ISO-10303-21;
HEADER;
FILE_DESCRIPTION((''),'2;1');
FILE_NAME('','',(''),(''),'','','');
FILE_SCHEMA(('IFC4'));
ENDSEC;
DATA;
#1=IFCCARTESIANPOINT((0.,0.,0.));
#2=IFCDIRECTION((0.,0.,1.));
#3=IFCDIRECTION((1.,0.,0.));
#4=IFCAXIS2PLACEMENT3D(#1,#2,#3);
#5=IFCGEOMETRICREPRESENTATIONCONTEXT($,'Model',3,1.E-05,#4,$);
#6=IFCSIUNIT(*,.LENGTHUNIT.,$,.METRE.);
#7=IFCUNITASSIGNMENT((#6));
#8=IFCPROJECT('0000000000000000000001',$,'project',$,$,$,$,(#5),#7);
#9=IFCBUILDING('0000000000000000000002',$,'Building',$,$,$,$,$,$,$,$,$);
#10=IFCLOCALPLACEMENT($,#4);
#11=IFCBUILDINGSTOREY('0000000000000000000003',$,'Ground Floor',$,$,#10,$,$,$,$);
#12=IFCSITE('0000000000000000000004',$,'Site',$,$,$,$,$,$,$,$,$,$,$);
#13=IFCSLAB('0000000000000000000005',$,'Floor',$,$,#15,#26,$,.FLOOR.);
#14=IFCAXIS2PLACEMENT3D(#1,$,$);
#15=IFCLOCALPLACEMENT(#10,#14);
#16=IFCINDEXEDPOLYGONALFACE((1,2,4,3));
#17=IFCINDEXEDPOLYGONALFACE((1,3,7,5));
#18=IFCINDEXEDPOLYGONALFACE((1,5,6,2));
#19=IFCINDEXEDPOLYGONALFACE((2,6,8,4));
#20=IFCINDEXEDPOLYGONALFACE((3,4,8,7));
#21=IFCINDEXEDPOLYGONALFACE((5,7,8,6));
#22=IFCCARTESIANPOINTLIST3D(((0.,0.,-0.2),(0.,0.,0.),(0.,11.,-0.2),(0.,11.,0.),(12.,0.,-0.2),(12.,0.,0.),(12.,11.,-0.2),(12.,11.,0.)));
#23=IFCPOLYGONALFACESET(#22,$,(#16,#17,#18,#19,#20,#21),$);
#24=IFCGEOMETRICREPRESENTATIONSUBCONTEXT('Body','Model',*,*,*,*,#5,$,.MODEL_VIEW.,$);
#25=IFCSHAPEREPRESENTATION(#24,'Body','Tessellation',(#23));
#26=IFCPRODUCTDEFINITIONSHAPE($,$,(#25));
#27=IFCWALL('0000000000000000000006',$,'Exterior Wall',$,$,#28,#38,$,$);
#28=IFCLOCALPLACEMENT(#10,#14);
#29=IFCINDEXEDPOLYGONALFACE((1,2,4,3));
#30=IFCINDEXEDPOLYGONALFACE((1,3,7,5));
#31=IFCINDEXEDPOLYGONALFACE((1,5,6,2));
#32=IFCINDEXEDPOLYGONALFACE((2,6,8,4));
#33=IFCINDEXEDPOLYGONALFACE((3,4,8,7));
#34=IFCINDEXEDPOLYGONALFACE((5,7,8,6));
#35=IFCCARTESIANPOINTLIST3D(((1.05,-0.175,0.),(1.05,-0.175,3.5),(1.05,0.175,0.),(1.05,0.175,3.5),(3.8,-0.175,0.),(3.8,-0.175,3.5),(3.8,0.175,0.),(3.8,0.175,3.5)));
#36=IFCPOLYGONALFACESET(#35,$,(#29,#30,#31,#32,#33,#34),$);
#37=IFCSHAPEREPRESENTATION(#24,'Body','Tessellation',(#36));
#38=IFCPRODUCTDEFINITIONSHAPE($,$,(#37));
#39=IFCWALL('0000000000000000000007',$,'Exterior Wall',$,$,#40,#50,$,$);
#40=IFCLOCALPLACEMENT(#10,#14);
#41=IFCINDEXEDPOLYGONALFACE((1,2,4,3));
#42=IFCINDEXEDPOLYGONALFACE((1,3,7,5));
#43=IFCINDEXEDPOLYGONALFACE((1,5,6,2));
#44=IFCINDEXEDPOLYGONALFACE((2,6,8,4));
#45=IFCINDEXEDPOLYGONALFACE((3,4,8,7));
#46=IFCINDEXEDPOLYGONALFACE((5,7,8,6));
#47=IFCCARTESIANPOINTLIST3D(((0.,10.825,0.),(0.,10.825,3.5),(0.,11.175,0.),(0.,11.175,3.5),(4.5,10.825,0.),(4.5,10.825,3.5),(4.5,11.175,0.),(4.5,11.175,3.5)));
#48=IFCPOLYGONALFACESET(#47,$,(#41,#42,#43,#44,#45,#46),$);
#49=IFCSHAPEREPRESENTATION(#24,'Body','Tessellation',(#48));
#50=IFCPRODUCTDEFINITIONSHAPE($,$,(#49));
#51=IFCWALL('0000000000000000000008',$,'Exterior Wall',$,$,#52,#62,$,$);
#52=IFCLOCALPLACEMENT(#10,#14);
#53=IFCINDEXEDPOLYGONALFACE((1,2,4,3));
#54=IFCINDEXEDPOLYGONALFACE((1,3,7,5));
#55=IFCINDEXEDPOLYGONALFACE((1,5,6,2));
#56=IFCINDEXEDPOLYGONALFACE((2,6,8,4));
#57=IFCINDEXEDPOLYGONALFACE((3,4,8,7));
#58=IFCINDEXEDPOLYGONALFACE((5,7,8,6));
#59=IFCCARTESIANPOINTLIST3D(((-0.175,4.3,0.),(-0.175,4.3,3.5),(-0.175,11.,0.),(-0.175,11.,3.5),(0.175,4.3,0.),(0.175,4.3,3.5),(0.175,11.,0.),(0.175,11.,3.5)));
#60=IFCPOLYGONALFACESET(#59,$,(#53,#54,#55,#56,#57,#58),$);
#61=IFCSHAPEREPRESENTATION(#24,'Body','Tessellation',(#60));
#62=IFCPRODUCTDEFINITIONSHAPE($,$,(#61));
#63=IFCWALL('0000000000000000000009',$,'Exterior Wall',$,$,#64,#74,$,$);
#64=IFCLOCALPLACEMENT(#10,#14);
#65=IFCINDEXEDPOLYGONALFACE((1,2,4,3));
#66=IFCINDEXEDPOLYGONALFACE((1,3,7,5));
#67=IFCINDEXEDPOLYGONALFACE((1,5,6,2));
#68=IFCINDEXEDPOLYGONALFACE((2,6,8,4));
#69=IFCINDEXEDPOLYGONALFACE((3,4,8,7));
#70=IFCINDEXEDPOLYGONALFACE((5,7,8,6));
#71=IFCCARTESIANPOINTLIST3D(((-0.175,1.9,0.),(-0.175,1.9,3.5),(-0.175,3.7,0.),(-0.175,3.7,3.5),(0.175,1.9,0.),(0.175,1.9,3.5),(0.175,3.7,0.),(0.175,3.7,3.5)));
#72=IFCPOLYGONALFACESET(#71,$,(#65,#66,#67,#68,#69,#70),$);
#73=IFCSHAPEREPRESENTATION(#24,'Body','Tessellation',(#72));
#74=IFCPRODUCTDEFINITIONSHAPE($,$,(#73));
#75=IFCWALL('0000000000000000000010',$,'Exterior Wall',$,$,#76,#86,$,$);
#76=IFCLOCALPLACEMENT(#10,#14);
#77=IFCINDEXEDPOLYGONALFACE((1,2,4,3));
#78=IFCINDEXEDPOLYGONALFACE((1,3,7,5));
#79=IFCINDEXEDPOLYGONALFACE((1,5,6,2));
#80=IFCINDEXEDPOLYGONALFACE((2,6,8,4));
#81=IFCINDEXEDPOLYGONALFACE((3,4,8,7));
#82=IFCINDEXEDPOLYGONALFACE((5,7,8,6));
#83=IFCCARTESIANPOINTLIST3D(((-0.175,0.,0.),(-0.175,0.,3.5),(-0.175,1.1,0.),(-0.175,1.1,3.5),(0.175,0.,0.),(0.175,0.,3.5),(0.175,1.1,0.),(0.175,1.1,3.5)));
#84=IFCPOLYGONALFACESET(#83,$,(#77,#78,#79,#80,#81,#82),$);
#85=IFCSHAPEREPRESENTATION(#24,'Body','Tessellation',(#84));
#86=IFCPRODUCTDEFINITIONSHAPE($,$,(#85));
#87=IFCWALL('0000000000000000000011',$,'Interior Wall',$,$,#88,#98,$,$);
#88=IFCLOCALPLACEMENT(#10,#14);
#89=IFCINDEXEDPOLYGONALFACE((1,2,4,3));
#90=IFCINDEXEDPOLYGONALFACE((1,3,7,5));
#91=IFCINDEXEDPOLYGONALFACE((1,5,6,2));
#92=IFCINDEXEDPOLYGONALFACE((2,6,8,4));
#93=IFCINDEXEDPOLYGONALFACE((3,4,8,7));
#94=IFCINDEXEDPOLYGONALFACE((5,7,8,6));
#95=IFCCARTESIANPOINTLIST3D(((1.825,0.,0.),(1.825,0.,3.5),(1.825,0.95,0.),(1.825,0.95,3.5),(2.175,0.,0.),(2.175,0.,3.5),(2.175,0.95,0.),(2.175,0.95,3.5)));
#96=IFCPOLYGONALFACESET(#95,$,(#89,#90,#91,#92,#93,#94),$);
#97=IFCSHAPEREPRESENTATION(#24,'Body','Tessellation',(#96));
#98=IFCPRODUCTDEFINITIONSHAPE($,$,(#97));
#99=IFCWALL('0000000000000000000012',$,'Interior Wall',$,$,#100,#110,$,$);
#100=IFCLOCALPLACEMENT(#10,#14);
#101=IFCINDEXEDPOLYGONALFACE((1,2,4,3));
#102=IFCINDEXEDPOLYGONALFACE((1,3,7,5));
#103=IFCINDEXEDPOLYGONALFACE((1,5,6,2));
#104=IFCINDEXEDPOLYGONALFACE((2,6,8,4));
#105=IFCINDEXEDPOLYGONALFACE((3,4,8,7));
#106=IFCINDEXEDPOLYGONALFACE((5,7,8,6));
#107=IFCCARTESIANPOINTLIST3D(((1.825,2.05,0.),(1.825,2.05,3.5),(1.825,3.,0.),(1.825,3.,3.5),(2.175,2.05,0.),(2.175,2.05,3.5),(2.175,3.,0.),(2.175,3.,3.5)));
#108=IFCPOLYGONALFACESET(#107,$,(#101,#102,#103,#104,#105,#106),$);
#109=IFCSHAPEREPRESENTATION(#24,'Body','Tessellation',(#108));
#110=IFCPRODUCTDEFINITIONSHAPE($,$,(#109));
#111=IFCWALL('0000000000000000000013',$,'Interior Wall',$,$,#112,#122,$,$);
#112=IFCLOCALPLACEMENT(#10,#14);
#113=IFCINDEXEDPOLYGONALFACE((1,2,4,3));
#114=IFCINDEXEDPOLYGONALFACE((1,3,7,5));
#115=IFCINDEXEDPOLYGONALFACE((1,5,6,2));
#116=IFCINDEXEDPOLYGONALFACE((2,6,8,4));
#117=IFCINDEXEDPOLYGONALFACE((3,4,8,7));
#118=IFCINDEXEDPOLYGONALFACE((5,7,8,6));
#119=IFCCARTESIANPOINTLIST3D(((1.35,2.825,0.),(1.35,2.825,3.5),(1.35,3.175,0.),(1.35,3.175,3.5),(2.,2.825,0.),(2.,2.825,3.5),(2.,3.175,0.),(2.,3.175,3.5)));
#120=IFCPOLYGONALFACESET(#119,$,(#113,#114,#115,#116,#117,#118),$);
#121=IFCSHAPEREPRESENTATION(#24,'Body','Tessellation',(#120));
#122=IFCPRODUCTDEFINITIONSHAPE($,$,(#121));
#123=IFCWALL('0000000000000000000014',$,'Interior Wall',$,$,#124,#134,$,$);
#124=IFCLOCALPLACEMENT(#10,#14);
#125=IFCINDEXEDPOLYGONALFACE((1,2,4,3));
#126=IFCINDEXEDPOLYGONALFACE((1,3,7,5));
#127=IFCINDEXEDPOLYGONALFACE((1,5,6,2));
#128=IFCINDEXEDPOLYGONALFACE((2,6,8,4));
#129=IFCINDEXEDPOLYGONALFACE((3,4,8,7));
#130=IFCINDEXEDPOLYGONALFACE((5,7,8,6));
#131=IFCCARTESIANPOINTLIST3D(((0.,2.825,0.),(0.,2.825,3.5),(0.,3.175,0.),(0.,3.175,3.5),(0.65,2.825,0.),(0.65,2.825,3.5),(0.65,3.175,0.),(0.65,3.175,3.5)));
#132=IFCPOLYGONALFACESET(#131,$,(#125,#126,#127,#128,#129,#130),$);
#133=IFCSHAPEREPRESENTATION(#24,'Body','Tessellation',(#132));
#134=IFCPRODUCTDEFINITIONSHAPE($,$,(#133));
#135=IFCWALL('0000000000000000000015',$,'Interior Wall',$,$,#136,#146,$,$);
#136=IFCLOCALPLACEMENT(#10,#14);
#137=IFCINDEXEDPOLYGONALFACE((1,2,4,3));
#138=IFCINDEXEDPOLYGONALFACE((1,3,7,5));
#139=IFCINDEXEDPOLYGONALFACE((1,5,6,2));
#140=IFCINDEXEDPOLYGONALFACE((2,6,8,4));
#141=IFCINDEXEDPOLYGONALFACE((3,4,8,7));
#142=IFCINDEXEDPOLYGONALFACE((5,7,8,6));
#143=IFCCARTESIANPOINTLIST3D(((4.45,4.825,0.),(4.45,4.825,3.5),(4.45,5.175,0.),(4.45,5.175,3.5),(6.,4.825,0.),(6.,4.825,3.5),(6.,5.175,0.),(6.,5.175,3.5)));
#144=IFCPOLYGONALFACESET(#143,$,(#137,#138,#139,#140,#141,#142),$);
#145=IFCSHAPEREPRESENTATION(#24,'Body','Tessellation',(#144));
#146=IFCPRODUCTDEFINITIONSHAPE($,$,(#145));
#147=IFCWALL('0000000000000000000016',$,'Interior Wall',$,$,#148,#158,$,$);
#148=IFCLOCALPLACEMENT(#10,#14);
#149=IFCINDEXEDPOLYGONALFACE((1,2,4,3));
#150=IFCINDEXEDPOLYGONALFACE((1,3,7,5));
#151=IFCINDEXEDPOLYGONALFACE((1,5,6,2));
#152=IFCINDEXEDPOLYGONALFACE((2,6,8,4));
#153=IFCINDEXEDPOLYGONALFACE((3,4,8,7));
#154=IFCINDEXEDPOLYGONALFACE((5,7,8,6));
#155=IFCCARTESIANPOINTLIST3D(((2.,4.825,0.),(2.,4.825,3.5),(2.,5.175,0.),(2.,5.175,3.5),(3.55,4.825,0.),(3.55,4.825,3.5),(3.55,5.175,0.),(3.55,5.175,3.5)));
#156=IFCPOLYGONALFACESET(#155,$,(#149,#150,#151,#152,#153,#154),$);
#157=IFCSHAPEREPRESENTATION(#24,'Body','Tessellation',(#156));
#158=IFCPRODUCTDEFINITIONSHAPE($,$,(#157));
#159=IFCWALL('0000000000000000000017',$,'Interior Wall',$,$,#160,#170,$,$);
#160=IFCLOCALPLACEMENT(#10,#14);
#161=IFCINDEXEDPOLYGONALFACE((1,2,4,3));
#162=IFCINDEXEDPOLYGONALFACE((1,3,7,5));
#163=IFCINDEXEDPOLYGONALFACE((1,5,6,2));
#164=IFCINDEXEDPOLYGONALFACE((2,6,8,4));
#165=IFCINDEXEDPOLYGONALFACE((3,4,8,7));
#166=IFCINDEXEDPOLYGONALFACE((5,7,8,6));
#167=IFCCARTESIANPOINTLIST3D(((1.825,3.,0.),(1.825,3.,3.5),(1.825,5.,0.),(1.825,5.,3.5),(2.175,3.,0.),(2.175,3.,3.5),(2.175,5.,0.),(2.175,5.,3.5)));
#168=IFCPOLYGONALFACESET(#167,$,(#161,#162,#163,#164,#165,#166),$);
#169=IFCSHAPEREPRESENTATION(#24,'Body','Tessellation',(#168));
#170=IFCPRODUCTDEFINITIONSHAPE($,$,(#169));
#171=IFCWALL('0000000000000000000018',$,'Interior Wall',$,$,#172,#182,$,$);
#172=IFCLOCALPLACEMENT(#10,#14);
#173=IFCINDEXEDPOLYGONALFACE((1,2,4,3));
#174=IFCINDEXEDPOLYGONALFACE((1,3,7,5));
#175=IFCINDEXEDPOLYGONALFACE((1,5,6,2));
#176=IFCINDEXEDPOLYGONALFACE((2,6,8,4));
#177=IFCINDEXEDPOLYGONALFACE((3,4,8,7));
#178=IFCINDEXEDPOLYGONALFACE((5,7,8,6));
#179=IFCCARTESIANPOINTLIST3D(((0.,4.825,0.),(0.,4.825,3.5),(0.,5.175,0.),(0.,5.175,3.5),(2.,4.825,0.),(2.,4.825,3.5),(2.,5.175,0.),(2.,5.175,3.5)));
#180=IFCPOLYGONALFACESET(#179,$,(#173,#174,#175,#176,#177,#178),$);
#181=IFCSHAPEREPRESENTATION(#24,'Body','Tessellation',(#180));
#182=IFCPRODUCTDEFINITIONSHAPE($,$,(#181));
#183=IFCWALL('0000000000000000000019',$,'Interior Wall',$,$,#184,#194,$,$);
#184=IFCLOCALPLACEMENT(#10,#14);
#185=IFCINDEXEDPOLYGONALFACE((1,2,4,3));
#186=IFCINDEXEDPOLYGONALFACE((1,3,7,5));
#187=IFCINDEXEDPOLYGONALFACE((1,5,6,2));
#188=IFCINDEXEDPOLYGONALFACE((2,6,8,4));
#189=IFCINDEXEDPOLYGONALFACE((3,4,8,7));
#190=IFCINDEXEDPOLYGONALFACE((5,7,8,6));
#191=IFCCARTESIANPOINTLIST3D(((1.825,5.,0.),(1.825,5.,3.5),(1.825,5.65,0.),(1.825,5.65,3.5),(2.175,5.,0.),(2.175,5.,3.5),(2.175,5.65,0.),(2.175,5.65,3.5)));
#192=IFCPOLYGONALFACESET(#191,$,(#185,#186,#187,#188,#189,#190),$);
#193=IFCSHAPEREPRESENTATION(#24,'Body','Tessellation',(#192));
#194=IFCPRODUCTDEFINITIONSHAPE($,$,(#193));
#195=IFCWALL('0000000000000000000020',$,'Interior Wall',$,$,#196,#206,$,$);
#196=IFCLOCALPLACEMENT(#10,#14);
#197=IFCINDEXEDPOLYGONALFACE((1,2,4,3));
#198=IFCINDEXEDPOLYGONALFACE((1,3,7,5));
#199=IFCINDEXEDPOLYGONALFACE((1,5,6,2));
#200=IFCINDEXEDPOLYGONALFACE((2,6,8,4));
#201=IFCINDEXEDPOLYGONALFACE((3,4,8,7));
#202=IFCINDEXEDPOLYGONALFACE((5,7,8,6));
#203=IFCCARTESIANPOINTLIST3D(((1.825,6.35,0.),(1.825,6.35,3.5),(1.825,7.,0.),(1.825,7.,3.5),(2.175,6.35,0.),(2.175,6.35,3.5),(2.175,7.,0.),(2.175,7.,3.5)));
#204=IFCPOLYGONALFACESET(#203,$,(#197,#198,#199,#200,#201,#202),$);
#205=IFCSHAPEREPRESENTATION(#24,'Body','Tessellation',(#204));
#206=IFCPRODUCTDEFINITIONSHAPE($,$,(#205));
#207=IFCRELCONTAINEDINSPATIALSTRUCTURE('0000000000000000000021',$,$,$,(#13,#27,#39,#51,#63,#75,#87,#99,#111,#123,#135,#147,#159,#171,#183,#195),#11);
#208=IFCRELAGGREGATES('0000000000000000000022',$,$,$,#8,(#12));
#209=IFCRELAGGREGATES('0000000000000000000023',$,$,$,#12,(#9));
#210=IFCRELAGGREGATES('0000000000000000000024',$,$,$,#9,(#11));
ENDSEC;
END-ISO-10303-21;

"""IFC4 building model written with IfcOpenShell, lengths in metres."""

from ifc_helpers import new_model, si_unit, frame, origin_with_axes, place, context, subcontext, project, spatial, indexed_curve, outline, extrude, element, save


model = new_model("IFC4")

# Units and contexts
model_context = context("Model", 3, precision=1e-05, world=origin_with_axes())
body_context = subcontext(model_context, "Body", "Model", "MODEL_VIEW")
ifc_project = project(units=[si_unit("LENGTHUNIT", "METRE")], contexts=[model_context])

# Site, building, storey
site = spatial("IfcSite", under=ifc_project, Name="Site")
building = spatial("IfcBuilding", under=site, Name="Building")
storey_placement = place(None, origin_with_axes())
storey = spatial("IfcBuildingStorey", under=building, at=storey_placement, Name="Ground Floor")

# Slab
slab_placement = place(storey_placement, frame((0.0, 0.0, -0.2), z_axis=(0.0, 0.0, 1.0), x_axis=(1.0, 0.0, 0.0)))
element("IfcSlab", 1, at=slab_placement, inside=storey, Name="Floor", PredefinedType="FLOOR", context=body_context, shape_type="SweptSolid", body=[
    extrude(outline(indexed_curve([(0.0, 0.0), (12.0, 0.0), (12.0, 11.0), (0.0, 11.0)])), None, (0.0, 0.0, 1.0), 0.2),
])

# Walls
wall_1_placement = place(storey_placement, frame((1.05, 0.0, 0.0), z_axis=(0.0, 0.0, 1.0), x_axis=(1.0, 0.0, 0.0)))
element("IfcWall", 2, at=wall_1_placement, inside=storey, Name="Exterior Wall", context=body_context, shape_type="SweptSolid", body=[
    extrude(outline(indexed_curve([(0.0, 0.0), (0.0, 0.35), (2.75, 0.35), (2.75, 0.0), (0.0, 0.0)], self_intersect=False)), frame((0.0, -0.175, 0.0), z_axis=(0.0, 0.0, 1.0), x_axis=(1.0, 0.0, 0.0)), (0.0, 0.0, 1.0), 3.5),
])
wall_2_placement = place(storey_placement, frame((4.5, 11.0, 0.0), z_axis=(0.0, 0.0, 1.0), x_axis=(-1.0, 0.0, 0.0)))
element("IfcWall", 3, at=wall_2_placement, inside=storey, Name="Exterior Wall", context=body_context, shape_type="SweptSolid", body=[
    extrude(outline(indexed_curve([(0.0, 0.0), (0.0, 0.35), (4.5, 0.35), (4.5, 0.0), (0.0, 0.0)], self_intersect=False)), frame((0.0, -0.175, 0.0), z_axis=(0.0, 0.0, 1.0), x_axis=(1.0, 0.0, 0.0)), (0.0, 0.0, 1.0), 3.5),
])
wall_3_placement = place(storey_placement, frame((0.0, 11.0, 0.0), z_axis=(0.0, 0.0, 1.0), x_axis=(0.0, -1.0, 0.0)))
element("IfcWall", 4, at=wall_3_placement, inside=storey, Name="Exterior Wall", context=body_context, shape_type="SweptSolid", body=[
    extrude(outline(indexed_curve([(0.0, 0.0), (0.0, 0.35), (6.7, 0.35), (6.7, 0.0), (0.0, 0.0)], self_intersect=False)), frame((0.0, -0.175, 0.0), z_axis=(0.0, 0.0, 1.0), x_axis=(1.0, 0.0, 0.0)), (0.0, 0.0, 1.0), 3.5),
])
wall_4_placement = place(storey_placement, frame((0.0, 3.7, 0.0), z_axis=(0.0, 0.0, 1.0), x_axis=(0.0, -1.0, 0.0)))
element("IfcWall", 5, at=wall_4_placement, inside=storey, Name="Exterior Wall", context=body_context, shape_type="SweptSolid", body=[
    extrude(outline(indexed_curve([(0.0, 0.0), (0.0, 0.35), (1.8, 0.35), (1.8, 0.0), (0.0, 0.0)], self_intersect=False)), frame((0.0, -0.175, 0.0), z_axis=(0.0, 0.0, 1.0), x_axis=(1.0, 0.0, 0.0)), (0.0, 0.0, 1.0), 3.5),
])
wall_5_placement = place(storey_placement, frame((0.0, 1.1, 0.0), z_axis=(0.0, 0.0, 1.0), x_axis=(0.0, -1.0, 0.0)))
element("IfcWall", 6, at=wall_5_placement, inside=storey, Name="Exterior Wall", context=body_context, shape_type="SweptSolid", body=[
    extrude(outline(indexed_curve([(0.0, 0.0), (0.0, 0.35), (1.1, 0.35), (1.1, 0.0), (0.0, 0.0)], self_intersect=False)), frame((0.0, -0.175, 0.0), z_axis=(0.0, 0.0, 1.0), x_axis=(1.0, 0.0, 0.0)), (0.0, 0.0, 1.0), 3.5),
])
wall_6_placement = place(storey_placement, frame((2.0, 0.0, 0.0), z_axis=(0.0, 0.0, 1.0), x_axis=(0.0, 1.0, 0.0)))
element("IfcWall", 7, at=wall_6_placement, inside=storey, Name="Interior Wall", context=body_context, shape_type="SweptSolid", body=[
    extrude(outline(indexed_curve([(0.0, 0.0), (0.0, 0.35), (0.95, 0.35), (0.95, 0.0), (0.0, 0.0)], self_intersect=False)), frame((0.0, -0.175, 0.0), z_axis=(0.0, 0.0, 1.0), x_axis=(1.0, 0.0, 0.0)), (0.0, 0.0, 1.0), 3.5),
])
wall_7_placement = place(storey_placement, frame((2.0, 2.05, 0.0), z_axis=(0.0, 0.0, 1.0), x_axis=(0.0, 1.0, 0.0)))
element("IfcWall", 8, at=wall_7_placement, inside=storey, Name="Interior Wall", context=body_context, shape_type="SweptSolid", body=[
    extrude(outline(indexed_curve([(0.0, 0.0), (0.0, 0.35), (0.95, 0.35), (0.95, 0.0), (0.0, 0.0)], self_intersect=False)), frame((0.0, -0.175, 0.0), z_axis=(0.0, 0.0, 1.0), x_axis=(1.0, 0.0, 0.0)), (0.0, 0.0, 1.0), 3.5),
])
for number, where, z_axis, x_axis, name in (
    (9, (2.0, 3.0, 0.0), (0.0, 0.0, 1.0), (-1.0, 0.0, 0.0), "Interior Wall"),
    (10, (0.65, 3.0, 0.0), (0.0, 0.0, 1.0), (-1.0, 0.0, 0.0), "Interior Wall"),
):
    element("IfcWall", number, at=place(storey_placement, frame(where, z_axis=z_axis, x_axis=x_axis)), inside=storey, Name=name, context=body_context, shape_type="SweptSolid", body=[
        extrude(outline(indexed_curve([(0.0, 0.0), (0.0, 0.35), (0.65, 0.35), (0.65, 0.0), (0.0, 0.0)], self_intersect=False)), frame((0.0, -0.175, 0.0), z_axis=(0.0, 0.0, 1.0), x_axis=(1.0, 0.0, 0.0)), (0.0, 0.0, 1.0), 3.5),
    ])
for number, where, z_axis, x_axis, name in (
    (11, (6.0, 5.0, 0.0), (0.0, 0.0, 1.0), (-1.0, 0.0, 0.0), "Interior Wall"),
    (12, (3.55, 5.0, 0.0), (0.0, 0.0, 1.0), (-1.0, 0.0, 0.0), "Interior Wall"),
):
    element("IfcWall", number, at=place(storey_placement, frame(where, z_axis=z_axis, x_axis=x_axis)), inside=storey, Name=name, context=body_context, shape_type="SweptSolid", body=[
        extrude(outline(indexed_curve([(0.0, 0.0), (0.0, 0.35), (1.55, 0.35), (1.55, 0.0), (0.0, 0.0)], self_intersect=False)), frame((0.0, -0.175, 0.0), z_axis=(0.0, 0.0, 1.0), x_axis=(1.0, 0.0, 0.0)), (0.0, 0.0, 1.0), 3.5),
    ])
for number, where, z_axis, x_axis, name in (
    (13, (2.0, 5.0, 0.0), (0.0, 0.0, 1.0), (0.0, -1.0, 0.0), "Interior Wall"),
    (14, (2.0, 5.0, 0.0), (0.0, 0.0, 1.0), (-1.0, 0.0, 0.0), "Interior Wall"),
):
    element("IfcWall", number, at=place(storey_placement, frame(where, z_axis=z_axis, x_axis=x_axis)), inside=storey, Name=name, context=body_context, shape_type="SweptSolid", body=[
        extrude(outline(indexed_curve([(0.0, 0.0), (0.0, 0.35), (2.0, 0.35), (2.0, 0.0), (0.0, 0.0)], self_intersect=False)), frame((0.0, -0.175, 0.0), z_axis=(0.0, 0.0, 1.0), x_axis=(1.0, 0.0, 0.0)), (0.0, 0.0, 1.0), 3.5),
    ])
for number, where, z_axis, x_axis, name in (
    (15, (2.0, 5.0, 0.0), (0.0, 0.0, 1.0), (0.0, 1.0, 0.0), "Interior Wall"),
    (16, (2.0, 6.35, 0.0), (0.0, 0.0, 1.0), (0.0, 1.0, 0.0), "Interior Wall"),
):
    element("IfcWall", number, at=place(storey_placement, frame(where, z_axis=z_axis, x_axis=x_axis)), inside=storey, Name=name, context=body_context, shape_type="SweptSolid", body=[
        extrude(outline(indexed_curve([(0.0, 0.0), (0.0, 0.35), (0.65, 0.35), (0.65, 0.0), (0.0, 0.0)], self_intersect=False)), frame((0.0, -0.175, 0.0), z_axis=(0.0, 0.0, 1.0), x_axis=(1.0, 0.0, 0.0)), (0.0, 0.0, 1.0), 3.5),
    ])

save(model, "model.ifc")
